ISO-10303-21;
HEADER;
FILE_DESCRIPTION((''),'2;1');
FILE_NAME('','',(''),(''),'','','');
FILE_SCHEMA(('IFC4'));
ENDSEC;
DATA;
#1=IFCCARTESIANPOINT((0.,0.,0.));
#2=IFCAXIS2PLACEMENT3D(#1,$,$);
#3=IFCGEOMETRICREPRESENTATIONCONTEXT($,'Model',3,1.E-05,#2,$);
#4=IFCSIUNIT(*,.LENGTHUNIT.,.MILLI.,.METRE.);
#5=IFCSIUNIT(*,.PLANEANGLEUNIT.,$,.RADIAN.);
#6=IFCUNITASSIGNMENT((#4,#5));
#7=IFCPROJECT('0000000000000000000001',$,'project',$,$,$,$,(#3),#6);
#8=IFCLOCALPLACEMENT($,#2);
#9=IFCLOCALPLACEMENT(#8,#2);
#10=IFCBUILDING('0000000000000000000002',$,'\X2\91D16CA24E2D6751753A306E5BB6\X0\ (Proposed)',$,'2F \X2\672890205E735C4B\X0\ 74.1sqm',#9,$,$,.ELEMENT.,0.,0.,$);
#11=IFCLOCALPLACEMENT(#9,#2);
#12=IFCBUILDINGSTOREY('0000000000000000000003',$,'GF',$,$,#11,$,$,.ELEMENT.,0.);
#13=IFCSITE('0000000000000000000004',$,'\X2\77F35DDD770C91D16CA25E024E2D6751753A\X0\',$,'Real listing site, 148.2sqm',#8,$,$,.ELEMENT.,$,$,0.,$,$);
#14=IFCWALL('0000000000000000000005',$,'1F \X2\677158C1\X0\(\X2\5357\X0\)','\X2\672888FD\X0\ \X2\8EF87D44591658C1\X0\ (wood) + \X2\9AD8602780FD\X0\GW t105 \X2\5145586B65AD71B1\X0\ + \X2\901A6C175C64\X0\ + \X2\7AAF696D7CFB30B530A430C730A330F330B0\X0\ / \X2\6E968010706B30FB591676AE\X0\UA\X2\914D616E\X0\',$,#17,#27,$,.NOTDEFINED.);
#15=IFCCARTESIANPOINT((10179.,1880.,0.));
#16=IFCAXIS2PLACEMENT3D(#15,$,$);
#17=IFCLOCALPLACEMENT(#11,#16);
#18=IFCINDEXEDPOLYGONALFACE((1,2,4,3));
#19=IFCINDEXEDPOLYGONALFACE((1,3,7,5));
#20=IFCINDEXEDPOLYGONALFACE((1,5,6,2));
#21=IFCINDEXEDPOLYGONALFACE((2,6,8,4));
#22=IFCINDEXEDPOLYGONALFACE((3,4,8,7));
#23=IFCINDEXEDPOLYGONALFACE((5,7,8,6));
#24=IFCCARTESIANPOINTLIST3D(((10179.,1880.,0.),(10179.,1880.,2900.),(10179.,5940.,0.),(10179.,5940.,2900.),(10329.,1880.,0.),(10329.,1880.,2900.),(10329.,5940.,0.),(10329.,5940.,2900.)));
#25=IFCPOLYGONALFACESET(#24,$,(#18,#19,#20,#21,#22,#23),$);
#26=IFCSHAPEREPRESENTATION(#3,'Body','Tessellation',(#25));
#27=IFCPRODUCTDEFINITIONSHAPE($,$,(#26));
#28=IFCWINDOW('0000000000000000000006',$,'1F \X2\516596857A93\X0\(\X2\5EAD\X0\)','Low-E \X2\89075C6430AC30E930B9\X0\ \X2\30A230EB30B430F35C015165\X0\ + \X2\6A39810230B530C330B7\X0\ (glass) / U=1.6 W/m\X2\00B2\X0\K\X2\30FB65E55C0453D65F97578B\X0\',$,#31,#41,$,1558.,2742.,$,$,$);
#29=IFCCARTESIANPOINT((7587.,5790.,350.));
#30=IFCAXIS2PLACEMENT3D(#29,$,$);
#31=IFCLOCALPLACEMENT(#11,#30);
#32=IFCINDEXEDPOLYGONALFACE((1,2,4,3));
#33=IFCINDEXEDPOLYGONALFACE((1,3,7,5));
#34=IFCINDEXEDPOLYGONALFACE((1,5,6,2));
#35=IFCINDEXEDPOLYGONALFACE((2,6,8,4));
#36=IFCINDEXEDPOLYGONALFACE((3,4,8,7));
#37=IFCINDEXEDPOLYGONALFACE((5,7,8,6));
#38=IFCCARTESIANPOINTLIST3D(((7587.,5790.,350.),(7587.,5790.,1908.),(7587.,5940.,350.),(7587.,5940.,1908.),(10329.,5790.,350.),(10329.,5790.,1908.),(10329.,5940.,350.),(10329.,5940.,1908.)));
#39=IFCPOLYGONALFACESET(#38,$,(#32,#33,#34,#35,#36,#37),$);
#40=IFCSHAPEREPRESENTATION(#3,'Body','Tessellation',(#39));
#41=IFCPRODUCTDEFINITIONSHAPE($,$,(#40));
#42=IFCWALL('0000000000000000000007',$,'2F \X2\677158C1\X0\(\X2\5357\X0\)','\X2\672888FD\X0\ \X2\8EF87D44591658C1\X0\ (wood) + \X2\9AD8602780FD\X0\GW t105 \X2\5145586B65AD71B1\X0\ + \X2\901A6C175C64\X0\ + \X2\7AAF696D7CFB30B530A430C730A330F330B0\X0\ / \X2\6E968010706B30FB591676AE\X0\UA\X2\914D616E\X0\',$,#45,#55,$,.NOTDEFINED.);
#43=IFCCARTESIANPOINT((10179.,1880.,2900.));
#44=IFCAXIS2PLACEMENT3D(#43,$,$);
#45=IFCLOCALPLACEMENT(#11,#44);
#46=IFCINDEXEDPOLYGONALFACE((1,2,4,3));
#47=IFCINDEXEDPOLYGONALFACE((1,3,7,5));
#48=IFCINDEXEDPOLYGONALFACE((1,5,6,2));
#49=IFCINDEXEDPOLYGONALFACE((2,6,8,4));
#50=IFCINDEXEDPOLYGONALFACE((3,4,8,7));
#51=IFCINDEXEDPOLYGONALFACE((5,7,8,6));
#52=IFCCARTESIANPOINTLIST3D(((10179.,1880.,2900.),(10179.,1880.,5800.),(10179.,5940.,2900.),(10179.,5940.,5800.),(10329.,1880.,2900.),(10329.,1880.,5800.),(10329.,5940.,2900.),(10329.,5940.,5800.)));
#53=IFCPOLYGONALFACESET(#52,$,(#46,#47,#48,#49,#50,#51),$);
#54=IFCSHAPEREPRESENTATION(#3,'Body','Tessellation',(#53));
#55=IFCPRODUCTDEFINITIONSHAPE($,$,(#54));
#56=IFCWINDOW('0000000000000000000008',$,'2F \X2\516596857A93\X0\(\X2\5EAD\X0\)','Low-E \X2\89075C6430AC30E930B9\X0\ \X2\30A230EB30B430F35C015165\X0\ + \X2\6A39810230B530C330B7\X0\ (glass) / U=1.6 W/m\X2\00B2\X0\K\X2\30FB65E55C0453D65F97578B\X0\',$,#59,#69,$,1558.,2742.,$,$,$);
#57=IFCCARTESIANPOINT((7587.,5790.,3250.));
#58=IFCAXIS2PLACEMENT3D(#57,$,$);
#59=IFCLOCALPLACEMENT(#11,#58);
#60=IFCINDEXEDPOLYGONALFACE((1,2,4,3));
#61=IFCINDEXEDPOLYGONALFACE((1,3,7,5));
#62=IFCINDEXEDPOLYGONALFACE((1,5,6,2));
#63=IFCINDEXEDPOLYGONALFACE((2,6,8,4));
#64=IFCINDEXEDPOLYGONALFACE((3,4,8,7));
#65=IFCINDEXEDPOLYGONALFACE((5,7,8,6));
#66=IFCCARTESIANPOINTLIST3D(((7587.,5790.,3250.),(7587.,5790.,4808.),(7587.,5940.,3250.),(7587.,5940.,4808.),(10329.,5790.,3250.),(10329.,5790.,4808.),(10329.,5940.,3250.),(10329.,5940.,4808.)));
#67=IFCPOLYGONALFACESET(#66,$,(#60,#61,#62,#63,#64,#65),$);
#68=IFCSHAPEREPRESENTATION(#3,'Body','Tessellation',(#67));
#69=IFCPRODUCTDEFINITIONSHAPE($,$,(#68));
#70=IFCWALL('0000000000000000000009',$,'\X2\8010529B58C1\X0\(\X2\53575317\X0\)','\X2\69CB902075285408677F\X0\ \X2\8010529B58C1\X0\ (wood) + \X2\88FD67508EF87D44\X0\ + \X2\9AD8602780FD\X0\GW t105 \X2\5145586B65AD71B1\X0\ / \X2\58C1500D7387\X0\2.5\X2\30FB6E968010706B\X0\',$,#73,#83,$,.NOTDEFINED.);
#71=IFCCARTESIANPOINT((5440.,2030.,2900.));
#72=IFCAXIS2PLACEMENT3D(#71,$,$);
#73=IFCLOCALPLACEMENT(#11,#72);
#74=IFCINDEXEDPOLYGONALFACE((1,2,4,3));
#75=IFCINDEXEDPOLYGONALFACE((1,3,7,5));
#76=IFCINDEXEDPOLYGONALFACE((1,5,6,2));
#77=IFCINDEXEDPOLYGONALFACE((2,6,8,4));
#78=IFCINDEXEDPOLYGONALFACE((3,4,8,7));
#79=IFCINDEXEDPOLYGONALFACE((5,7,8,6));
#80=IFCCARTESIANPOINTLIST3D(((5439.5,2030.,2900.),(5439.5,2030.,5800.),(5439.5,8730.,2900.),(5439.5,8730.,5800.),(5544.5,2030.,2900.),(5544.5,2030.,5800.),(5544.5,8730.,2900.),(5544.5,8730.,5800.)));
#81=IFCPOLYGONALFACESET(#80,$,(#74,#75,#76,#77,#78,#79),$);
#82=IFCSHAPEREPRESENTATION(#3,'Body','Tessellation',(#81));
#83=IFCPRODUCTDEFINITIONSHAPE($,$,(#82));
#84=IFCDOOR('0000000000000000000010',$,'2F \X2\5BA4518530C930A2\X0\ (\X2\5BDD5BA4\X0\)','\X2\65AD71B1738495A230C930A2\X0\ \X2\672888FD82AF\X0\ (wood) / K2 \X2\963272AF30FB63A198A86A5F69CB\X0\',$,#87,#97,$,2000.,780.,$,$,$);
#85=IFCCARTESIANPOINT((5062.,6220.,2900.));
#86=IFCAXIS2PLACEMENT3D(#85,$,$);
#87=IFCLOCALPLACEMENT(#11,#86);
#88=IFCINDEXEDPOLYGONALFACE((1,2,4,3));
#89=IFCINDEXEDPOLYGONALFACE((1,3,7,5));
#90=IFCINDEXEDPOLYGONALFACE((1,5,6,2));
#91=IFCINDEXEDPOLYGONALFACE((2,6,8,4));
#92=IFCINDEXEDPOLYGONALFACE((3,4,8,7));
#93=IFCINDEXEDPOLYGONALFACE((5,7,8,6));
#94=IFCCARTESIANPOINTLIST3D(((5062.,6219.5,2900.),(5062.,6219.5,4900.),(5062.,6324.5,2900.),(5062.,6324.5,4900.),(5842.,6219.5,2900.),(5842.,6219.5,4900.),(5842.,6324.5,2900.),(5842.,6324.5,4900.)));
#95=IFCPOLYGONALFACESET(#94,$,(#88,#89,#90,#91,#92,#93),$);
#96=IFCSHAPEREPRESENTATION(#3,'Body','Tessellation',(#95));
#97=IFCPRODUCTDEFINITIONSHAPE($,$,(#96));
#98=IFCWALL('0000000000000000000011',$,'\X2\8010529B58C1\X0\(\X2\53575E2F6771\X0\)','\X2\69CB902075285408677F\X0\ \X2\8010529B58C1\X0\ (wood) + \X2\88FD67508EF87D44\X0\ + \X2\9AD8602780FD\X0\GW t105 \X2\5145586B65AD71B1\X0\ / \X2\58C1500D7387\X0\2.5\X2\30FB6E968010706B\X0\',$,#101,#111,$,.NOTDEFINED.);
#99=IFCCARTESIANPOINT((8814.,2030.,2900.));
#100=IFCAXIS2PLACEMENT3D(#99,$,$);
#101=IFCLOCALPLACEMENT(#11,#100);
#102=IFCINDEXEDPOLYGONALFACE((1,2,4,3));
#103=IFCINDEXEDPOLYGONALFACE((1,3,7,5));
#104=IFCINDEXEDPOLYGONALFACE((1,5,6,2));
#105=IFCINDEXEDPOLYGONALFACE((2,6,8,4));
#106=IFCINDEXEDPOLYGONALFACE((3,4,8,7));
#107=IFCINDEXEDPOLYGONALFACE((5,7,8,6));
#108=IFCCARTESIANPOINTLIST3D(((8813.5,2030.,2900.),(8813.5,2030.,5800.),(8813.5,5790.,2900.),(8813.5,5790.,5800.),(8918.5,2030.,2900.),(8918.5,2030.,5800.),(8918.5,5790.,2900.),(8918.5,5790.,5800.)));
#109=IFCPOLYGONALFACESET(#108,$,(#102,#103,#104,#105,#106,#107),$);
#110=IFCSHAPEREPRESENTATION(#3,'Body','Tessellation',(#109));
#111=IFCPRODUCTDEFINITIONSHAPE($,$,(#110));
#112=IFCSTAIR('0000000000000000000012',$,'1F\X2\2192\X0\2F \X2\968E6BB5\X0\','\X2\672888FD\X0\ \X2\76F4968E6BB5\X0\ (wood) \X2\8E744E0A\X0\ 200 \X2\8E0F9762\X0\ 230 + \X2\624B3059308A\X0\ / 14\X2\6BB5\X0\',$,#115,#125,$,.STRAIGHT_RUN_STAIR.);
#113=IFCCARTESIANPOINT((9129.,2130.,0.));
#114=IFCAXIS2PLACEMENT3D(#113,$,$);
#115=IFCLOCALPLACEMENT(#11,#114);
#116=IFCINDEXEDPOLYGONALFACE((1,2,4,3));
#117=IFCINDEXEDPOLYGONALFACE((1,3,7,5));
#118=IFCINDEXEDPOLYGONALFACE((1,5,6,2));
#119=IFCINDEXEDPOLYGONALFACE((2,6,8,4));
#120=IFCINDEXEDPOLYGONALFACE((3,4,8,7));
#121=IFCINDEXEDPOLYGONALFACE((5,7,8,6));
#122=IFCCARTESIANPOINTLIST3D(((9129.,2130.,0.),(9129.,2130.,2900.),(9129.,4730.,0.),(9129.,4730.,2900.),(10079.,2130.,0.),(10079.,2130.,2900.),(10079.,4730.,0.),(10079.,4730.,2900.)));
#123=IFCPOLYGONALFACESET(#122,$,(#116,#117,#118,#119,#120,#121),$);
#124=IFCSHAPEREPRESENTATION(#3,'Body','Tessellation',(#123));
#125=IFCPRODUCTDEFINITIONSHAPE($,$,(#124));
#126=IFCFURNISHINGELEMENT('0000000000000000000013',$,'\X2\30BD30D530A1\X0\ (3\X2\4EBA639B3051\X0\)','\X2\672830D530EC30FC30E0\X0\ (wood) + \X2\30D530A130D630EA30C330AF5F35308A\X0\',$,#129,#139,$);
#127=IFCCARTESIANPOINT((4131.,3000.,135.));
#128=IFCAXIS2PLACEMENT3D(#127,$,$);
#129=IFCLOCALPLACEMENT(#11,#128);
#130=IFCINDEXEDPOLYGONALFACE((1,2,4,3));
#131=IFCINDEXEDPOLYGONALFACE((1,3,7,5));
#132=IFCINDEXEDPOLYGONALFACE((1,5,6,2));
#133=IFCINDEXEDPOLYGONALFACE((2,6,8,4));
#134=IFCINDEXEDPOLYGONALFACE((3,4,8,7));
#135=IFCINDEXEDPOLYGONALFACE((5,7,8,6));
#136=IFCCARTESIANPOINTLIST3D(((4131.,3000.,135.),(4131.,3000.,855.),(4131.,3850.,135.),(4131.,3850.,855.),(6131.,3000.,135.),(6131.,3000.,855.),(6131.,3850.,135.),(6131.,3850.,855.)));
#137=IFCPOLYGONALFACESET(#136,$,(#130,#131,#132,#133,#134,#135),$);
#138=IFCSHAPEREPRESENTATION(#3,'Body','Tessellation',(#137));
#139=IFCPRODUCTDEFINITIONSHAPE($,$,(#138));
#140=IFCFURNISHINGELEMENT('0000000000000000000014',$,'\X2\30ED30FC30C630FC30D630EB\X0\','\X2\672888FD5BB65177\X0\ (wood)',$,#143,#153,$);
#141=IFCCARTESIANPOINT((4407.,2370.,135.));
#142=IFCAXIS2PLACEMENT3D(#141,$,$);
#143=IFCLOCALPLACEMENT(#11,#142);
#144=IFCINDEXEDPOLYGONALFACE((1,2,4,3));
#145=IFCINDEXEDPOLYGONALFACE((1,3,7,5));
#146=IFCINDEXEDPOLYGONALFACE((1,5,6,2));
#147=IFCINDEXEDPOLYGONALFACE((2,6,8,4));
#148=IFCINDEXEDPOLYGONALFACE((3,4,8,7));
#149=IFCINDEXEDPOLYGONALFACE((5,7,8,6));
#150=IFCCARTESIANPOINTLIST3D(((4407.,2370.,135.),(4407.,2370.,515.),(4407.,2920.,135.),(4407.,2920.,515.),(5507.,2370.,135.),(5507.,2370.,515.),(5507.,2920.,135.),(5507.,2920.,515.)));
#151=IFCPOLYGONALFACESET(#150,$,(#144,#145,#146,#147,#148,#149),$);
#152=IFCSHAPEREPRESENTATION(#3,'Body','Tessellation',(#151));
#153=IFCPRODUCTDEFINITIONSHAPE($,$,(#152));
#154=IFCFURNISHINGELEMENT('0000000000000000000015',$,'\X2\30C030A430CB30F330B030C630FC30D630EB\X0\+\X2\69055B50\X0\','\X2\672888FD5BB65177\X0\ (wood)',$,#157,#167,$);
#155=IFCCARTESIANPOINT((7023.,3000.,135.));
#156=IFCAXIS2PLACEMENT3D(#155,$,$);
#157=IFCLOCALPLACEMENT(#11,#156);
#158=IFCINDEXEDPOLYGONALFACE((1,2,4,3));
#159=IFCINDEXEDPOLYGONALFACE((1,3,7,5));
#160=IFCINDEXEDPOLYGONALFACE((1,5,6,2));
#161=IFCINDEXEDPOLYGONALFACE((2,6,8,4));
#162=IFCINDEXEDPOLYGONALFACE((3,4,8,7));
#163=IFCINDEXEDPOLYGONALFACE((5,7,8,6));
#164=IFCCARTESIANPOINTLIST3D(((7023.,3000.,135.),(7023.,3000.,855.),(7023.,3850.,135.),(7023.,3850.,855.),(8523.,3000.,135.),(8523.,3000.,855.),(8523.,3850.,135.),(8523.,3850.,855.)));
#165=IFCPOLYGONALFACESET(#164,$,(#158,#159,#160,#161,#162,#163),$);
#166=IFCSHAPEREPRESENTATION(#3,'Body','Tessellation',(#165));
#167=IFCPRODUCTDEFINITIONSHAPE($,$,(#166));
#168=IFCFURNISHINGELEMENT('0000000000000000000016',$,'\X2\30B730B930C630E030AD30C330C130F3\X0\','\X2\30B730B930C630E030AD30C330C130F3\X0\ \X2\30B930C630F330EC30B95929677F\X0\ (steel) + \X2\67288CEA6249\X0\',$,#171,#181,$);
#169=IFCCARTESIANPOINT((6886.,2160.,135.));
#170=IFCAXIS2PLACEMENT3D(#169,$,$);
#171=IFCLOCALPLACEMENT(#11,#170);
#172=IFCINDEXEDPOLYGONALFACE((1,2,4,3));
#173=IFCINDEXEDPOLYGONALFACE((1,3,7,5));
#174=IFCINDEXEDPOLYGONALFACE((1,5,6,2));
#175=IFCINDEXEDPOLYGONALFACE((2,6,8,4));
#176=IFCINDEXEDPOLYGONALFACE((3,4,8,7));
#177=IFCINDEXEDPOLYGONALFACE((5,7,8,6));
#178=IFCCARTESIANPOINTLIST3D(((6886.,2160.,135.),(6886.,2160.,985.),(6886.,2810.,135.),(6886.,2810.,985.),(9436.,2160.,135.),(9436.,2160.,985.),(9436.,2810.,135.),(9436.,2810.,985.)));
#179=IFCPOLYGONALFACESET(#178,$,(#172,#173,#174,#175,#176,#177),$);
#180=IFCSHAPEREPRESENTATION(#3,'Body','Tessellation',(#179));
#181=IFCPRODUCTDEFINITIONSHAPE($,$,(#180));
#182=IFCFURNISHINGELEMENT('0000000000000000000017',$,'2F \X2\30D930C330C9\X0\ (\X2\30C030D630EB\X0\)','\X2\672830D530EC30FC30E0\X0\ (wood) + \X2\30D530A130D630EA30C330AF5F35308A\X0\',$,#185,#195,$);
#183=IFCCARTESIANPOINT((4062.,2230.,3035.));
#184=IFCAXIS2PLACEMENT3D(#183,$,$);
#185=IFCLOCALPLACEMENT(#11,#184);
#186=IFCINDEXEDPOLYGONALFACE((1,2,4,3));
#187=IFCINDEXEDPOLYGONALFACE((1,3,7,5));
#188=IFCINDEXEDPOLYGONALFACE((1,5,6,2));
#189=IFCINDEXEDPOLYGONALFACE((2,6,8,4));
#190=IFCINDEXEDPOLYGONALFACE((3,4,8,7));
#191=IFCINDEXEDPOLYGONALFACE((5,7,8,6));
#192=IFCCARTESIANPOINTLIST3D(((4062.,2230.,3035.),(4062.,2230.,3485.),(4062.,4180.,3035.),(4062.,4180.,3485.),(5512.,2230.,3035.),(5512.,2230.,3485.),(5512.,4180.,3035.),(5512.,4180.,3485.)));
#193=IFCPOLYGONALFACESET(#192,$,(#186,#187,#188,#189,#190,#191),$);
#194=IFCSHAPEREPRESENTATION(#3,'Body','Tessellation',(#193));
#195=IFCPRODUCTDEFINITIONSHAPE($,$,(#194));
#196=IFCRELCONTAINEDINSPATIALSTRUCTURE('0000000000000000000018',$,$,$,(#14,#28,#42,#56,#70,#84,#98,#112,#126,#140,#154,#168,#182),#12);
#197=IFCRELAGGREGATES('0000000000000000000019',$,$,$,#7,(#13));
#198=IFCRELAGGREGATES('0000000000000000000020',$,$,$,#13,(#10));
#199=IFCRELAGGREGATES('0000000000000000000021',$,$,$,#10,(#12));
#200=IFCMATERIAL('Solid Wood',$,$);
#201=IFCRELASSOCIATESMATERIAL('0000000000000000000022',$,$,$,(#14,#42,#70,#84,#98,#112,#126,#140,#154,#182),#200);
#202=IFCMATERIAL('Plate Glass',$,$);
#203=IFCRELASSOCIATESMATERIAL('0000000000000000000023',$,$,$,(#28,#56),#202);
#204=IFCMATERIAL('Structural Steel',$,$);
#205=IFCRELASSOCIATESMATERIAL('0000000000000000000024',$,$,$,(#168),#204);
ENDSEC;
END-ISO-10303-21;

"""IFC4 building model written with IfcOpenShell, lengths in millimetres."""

from ifc_helpers import new_model, si_unit, frame, frame_2d, origin, place, context, project, spatial, rectangle, extrude, material, element, fill, save


model = new_model("IFC4")

# Units and contexts
model_context = context("Model", 3, precision=1e-05, world=origin())
ifc_project = project(units=[si_unit("LENGTHUNIT", "METRE", prefix="MILLI"), si_unit("PLANEANGLEUNIT", "RADIAN")], contexts=[model_context])

# Site, building, storey
site_placement = place(None, origin())
site = spatial("IfcSite", under=ifc_project, at=site_placement, Name="石川県金沢市中村町", ObjectType="Real listing site, 148.2sqm", CompositionType="ELEMENT", RefElevation=0.0)
building_placement = place(site_placement, origin())
building = spatial("IfcBuilding", under=site, at=building_placement, Name="金沢中村町の家 (Proposed)", ObjectType="2F 木造平屋 74.1sqm", CompositionType="ELEMENT", ElevationOfRefHeight=0.0, ElevationOfTerrain=0.0)
storey_placement = place(building_placement, origin())
storey = spatial("IfcBuildingStorey", under=building, at=storey_placement, Name="GF", CompositionType="ELEMENT", Elevation=0.0)

# Wall, opening, window
ifc_material_1 = material(Name="Solid Wood")
wall_1_placement = place(storey_placement, frame((10179.0, 1880.0, 0.0)))
wall_1 = element("IfcWall", 1, at=wall_1_placement, inside=storey, material=ifc_material_1, Name="1F 東壁(南)", Description="木製 軸組外壁 (wood) + 高性能GW t105 充填断熱 + 通気層 + 窯業系サイディング / 準耐火・外皮UA配慮", PredefinedType="NOTDEFINED", context=model_context, shape_type="SweptSolid", body=[
    extrude(rectangle(XDim=150.0, YDim=4060.0, at=frame_2d((75.0, 2030.0))), frame((10179.0, 1880.0, 0.0)), (0.0, 0.0, 1.0), 2900.0),
])
opening_1_placement = place(storey_placement, frame((7587.0, 5790.0, 350.0)))
opening_1 = element("IfcOpeningElement", 2, at=opening_1_placement, cuts=wall_1, PredefinedType="NOTDEFINED", context=model_context, shape_type="SweptSolid", body=[
    extrude(rectangle(XDim=2742.0, YDim=150.0, at=frame_2d((1371.0, 75.0))), frame((7587.0, 5790.0, 350.0)), (0.0, 0.0, 1.0), 1558.0),
])
ifc_material_2 = material(Name="Plate Glass")
window_1_placement = place(storey_placement, frame((7587.0, 5790.0, 350.0)))
window_1 = element("IfcWindow", 3, at=window_1_placement, inside=storey, material=ifc_material_2, Name="1F 入隅窓(庭)", Description="Low-E 複層ガラス アルゴン封入 + 樹脂サッシ (glass) / U=1.6 W/m²K・日射取得型", OverallHeight=1558.0, OverallWidth=2742.0, context=model_context, shape_type="SweptSolid", body=[
    extrude(rectangle(XDim=2742.0, YDim=150.0, at=frame_2d((1371.0, 75.0))), frame((7587.0, 5790.0, 350.0)), (0.0, 0.0, 1.0), 1558.0),
])
fill(opening_1, window_1)

# Wall, opening, window
wall_2_placement = place(storey_placement, frame((10179.0, 1880.0, 2900.0)))
wall_2 = element("IfcWall", 4, at=wall_2_placement, inside=storey, material=ifc_material_1, Name="2F 東壁(南)", Description="木製 軸組外壁 (wood) + 高性能GW t105 充填断熱 + 通気層 + 窯業系サイディング / 準耐火・外皮UA配慮", PredefinedType="NOTDEFINED", context=model_context, shape_type="SweptSolid", body=[
    extrude(rectangle(XDim=150.0, YDim=4060.0, at=frame_2d((75.0, 2030.0))), frame((10179.0, 1880.0, 2900.0)), (0.0, 0.0, 1.0), 2900.0),
])
opening_2_placement = place(storey_placement, frame((7587.0, 5790.0, 3250.0)))
opening_2 = element("IfcOpeningElement", 5, at=opening_2_placement, cuts=wall_2, PredefinedType="NOTDEFINED", context=model_context, shape_type="SweptSolid", body=[
    extrude(rectangle(XDim=2742.0, YDim=150.0, at=frame_2d((1371.0, 75.0))), frame((7587.0, 5790.0, 3250.0)), (0.0, 0.0, 1.0), 1558.0),
])
window_2_placement = place(storey_placement, frame((7587.0, 5790.0, 3250.0)))
window_2 = element("IfcWindow", 6, at=window_2_placement, inside=storey, material=ifc_material_2, Name="2F 入隅窓(庭)", Description="Low-E 複層ガラス アルゴン封入 + 樹脂サッシ (glass) / U=1.6 W/m²K・日射取得型", OverallHeight=1558.0, OverallWidth=2742.0, context=model_context, shape_type="SweptSolid", body=[
    extrude(rectangle(XDim=2742.0, YDim=150.0, at=frame_2d((1371.0, 75.0))), frame((7587.0, 5790.0, 3250.0)), (0.0, 0.0, 1.0), 1558.0),
])
fill(opening_2, window_2)

# Wall, opening, door
wall_3_placement = place(storey_placement, frame((5440.0, 2030.0, 2900.0)))
wall_3 = element("IfcWall", 7, at=wall_3_placement, inside=storey, material=ifc_material_1, Name="耐力壁(南北)", Description="構造用合板 耐力壁 (wood) + 製材軸組 + 高性能GW t105 充填断熱 / 壁倍率2.5・準耐火", PredefinedType="NOTDEFINED", context=model_context, shape_type="SweptSolid", body=[
    extrude(rectangle(XDim=105.0, YDim=6700.0, at=frame_2d((52.0, 3350.0))), frame((5440.0, 2030.0, 2900.0)), (0.0, 0.0, 1.0), 2900.0),
])
opening_3_placement = place(storey_placement, frame((5062.0, 6220.0, 2900.0)))
opening_3 = element("IfcOpeningElement", 8, at=opening_3_placement, cuts=wall_3, PredefinedType="NOTDEFINED", context=model_context, shape_type="SweptSolid", body=[
    extrude(rectangle(XDim=780.0, YDim=105.0, at=frame_2d((390.0, 52.0))), frame((5062.0, 6220.0, 2900.0)), (0.0, 0.0, 1.0), 2000.0),
])
door_1_placement = place(storey_placement, frame((5062.0, 6220.0, 2900.0)))
door_1 = element("IfcDoor", 9, at=door_1_placement, inside=storey, material=ifc_material_1, Name="2F 室内ドア (寝室)", Description="断熱玄関ドア 木製芯 (wood) / K2 防犯・採風機構", OverallHeight=2000.0, OverallWidth=780.0, context=model_context, shape_type="SweptSolid", body=[
    extrude(rectangle(XDim=780.0, YDim=105.0, at=frame_2d((390.0, 52.0))), frame((5062.0, 6220.0, 2900.0)), (0.0, 0.0, 1.0), 2000.0),
])
fill(opening_3, door_1)

# Wall
wall_4_placement = place(storey_placement, frame((8814.0, 2030.0, 2900.0)))
element("IfcWall", 10, at=wall_4_placement, inside=storey, material=ifc_material_1, Name="耐力壁(南帯東)", Description="構造用合板 耐力壁 (wood) + 製材軸組 + 高性能GW t105 充填断熱 / 壁倍率2.5・準耐火", PredefinedType="NOTDEFINED", context=model_context, shape_type="SweptSolid", body=[
    extrude(rectangle(XDim=105.0, YDim=3760.0, at=frame_2d((52.0, 1880.0))), frame((8814.0, 2030.0, 2900.0)), (0.0, 0.0, 1.0), 2900.0),
])

# Stair
stair_placement = place(storey_placement, frame((9129.0, 2130.0, 0.0)))
element("IfcStair", 11, at=stair_placement, inside=storey, material=ifc_material_1, Name="1F→2F 階段", Description="木製 直階段 (wood) 蹴上 200 踏面 230 + 手すり / 14段", PredefinedType="STRAIGHT_RUN_STAIR", context=model_context, shape_type="SweptSolid", body=[
    extrude(rectangle(XDim=950.0, YDim=2600.0, at=frame_2d((475.0, 1300.0))), frame((9129.0, 2130.0, 0.0)), (0.0, 0.0, 1.0), 2900.0),
])

# Furnishing elements
furnishing_1_placement = place(storey_placement, frame((4131.0, 3000.0, 135.0)))
element("IfcFurnishingElement", 12, at=furnishing_1_placement, inside=storey, material=ifc_material_1, Name="ソファ (3人掛け)", Description="木フレーム (wood) + ファブリック張り", context=model_context, shape_type="SweptSolid", body=[
    extrude(rectangle(XDim=2000.0, YDim=850.0, at=frame_2d((1000.0, 425.0))), frame((4131.0, 3000.0, 135.0)), (0.0, 0.0, 1.0), 720.0),
])
furnishing_2_placement = place(storey_placement, frame((4407.0, 2370.0, 135.0)))
element("IfcFurnishingElement", 13, at=furnishing_2_placement, inside=storey, material=ifc_material_1, Name="ローテーブル", Description="木製家具 (wood)", context=model_context, shape_type="SweptSolid", body=[
    extrude(rectangle(XDim=1100.0, YDim=550.0, at=frame_2d((550.0, 275.0))), frame((4407.0, 2370.0, 135.0)), (0.0, 0.0, 1.0), 380.0),
])
furnishing_3_placement = place(storey_placement, frame((7023.0, 3000.0, 135.0)))
element("IfcFurnishingElement", 14, at=furnishing_3_placement, inside=storey, material=ifc_material_1, Name="ダイニングテーブル+椅子", Description="木製家具 (wood)", context=model_context, shape_type="SweptSolid", body=[
    extrude(rectangle(XDim=1500.0, YDim=850.0, at=frame_2d((750.0, 425.0))), frame((7023.0, 3000.0, 135.0)), (0.0, 0.0, 1.0), 720.0),
])
ifc_material_3 = material(Name="Structural Steel")
furnishing_4_placement = place(storey_placement, frame((6886.0, 2160.0, 135.0)))
element("IfcFurnishingElement", 15, at=furnishing_4_placement, inside=storey, material=ifc_material_3, Name="システムキッチン", Description="システムキッチン ステンレス天板 (steel) + 木質扉", context=model_context, shape_type="SweptSolid", body=[
    extrude(rectangle(XDim=2550.0, YDim=650.0, at=frame_2d((1275.0, 325.0))), frame((6886.0, 2160.0, 135.0)), (0.0, 0.0, 1.0), 850.0),
])
furnishing_5_placement = place(storey_placement, frame((4062.0, 2230.0, 3035.0)))
element("IfcFurnishingElement", 16, at=furnishing_5_placement, inside=storey, material=ifc_material_1, Name="2F ベッド (ダブル)", Description="木フレーム (wood) + ファブリック張り", context=model_context, shape_type="SweptSolid", body=[
    extrude(rectangle(XDim=1450.0, YDim=1950.0, at=frame_2d((725.0, 975.0))), frame((4062.0, 2230.0, 3035.0)), (0.0, 0.0, 1.0), 450.0),
])

save(model, "model.ifc")
